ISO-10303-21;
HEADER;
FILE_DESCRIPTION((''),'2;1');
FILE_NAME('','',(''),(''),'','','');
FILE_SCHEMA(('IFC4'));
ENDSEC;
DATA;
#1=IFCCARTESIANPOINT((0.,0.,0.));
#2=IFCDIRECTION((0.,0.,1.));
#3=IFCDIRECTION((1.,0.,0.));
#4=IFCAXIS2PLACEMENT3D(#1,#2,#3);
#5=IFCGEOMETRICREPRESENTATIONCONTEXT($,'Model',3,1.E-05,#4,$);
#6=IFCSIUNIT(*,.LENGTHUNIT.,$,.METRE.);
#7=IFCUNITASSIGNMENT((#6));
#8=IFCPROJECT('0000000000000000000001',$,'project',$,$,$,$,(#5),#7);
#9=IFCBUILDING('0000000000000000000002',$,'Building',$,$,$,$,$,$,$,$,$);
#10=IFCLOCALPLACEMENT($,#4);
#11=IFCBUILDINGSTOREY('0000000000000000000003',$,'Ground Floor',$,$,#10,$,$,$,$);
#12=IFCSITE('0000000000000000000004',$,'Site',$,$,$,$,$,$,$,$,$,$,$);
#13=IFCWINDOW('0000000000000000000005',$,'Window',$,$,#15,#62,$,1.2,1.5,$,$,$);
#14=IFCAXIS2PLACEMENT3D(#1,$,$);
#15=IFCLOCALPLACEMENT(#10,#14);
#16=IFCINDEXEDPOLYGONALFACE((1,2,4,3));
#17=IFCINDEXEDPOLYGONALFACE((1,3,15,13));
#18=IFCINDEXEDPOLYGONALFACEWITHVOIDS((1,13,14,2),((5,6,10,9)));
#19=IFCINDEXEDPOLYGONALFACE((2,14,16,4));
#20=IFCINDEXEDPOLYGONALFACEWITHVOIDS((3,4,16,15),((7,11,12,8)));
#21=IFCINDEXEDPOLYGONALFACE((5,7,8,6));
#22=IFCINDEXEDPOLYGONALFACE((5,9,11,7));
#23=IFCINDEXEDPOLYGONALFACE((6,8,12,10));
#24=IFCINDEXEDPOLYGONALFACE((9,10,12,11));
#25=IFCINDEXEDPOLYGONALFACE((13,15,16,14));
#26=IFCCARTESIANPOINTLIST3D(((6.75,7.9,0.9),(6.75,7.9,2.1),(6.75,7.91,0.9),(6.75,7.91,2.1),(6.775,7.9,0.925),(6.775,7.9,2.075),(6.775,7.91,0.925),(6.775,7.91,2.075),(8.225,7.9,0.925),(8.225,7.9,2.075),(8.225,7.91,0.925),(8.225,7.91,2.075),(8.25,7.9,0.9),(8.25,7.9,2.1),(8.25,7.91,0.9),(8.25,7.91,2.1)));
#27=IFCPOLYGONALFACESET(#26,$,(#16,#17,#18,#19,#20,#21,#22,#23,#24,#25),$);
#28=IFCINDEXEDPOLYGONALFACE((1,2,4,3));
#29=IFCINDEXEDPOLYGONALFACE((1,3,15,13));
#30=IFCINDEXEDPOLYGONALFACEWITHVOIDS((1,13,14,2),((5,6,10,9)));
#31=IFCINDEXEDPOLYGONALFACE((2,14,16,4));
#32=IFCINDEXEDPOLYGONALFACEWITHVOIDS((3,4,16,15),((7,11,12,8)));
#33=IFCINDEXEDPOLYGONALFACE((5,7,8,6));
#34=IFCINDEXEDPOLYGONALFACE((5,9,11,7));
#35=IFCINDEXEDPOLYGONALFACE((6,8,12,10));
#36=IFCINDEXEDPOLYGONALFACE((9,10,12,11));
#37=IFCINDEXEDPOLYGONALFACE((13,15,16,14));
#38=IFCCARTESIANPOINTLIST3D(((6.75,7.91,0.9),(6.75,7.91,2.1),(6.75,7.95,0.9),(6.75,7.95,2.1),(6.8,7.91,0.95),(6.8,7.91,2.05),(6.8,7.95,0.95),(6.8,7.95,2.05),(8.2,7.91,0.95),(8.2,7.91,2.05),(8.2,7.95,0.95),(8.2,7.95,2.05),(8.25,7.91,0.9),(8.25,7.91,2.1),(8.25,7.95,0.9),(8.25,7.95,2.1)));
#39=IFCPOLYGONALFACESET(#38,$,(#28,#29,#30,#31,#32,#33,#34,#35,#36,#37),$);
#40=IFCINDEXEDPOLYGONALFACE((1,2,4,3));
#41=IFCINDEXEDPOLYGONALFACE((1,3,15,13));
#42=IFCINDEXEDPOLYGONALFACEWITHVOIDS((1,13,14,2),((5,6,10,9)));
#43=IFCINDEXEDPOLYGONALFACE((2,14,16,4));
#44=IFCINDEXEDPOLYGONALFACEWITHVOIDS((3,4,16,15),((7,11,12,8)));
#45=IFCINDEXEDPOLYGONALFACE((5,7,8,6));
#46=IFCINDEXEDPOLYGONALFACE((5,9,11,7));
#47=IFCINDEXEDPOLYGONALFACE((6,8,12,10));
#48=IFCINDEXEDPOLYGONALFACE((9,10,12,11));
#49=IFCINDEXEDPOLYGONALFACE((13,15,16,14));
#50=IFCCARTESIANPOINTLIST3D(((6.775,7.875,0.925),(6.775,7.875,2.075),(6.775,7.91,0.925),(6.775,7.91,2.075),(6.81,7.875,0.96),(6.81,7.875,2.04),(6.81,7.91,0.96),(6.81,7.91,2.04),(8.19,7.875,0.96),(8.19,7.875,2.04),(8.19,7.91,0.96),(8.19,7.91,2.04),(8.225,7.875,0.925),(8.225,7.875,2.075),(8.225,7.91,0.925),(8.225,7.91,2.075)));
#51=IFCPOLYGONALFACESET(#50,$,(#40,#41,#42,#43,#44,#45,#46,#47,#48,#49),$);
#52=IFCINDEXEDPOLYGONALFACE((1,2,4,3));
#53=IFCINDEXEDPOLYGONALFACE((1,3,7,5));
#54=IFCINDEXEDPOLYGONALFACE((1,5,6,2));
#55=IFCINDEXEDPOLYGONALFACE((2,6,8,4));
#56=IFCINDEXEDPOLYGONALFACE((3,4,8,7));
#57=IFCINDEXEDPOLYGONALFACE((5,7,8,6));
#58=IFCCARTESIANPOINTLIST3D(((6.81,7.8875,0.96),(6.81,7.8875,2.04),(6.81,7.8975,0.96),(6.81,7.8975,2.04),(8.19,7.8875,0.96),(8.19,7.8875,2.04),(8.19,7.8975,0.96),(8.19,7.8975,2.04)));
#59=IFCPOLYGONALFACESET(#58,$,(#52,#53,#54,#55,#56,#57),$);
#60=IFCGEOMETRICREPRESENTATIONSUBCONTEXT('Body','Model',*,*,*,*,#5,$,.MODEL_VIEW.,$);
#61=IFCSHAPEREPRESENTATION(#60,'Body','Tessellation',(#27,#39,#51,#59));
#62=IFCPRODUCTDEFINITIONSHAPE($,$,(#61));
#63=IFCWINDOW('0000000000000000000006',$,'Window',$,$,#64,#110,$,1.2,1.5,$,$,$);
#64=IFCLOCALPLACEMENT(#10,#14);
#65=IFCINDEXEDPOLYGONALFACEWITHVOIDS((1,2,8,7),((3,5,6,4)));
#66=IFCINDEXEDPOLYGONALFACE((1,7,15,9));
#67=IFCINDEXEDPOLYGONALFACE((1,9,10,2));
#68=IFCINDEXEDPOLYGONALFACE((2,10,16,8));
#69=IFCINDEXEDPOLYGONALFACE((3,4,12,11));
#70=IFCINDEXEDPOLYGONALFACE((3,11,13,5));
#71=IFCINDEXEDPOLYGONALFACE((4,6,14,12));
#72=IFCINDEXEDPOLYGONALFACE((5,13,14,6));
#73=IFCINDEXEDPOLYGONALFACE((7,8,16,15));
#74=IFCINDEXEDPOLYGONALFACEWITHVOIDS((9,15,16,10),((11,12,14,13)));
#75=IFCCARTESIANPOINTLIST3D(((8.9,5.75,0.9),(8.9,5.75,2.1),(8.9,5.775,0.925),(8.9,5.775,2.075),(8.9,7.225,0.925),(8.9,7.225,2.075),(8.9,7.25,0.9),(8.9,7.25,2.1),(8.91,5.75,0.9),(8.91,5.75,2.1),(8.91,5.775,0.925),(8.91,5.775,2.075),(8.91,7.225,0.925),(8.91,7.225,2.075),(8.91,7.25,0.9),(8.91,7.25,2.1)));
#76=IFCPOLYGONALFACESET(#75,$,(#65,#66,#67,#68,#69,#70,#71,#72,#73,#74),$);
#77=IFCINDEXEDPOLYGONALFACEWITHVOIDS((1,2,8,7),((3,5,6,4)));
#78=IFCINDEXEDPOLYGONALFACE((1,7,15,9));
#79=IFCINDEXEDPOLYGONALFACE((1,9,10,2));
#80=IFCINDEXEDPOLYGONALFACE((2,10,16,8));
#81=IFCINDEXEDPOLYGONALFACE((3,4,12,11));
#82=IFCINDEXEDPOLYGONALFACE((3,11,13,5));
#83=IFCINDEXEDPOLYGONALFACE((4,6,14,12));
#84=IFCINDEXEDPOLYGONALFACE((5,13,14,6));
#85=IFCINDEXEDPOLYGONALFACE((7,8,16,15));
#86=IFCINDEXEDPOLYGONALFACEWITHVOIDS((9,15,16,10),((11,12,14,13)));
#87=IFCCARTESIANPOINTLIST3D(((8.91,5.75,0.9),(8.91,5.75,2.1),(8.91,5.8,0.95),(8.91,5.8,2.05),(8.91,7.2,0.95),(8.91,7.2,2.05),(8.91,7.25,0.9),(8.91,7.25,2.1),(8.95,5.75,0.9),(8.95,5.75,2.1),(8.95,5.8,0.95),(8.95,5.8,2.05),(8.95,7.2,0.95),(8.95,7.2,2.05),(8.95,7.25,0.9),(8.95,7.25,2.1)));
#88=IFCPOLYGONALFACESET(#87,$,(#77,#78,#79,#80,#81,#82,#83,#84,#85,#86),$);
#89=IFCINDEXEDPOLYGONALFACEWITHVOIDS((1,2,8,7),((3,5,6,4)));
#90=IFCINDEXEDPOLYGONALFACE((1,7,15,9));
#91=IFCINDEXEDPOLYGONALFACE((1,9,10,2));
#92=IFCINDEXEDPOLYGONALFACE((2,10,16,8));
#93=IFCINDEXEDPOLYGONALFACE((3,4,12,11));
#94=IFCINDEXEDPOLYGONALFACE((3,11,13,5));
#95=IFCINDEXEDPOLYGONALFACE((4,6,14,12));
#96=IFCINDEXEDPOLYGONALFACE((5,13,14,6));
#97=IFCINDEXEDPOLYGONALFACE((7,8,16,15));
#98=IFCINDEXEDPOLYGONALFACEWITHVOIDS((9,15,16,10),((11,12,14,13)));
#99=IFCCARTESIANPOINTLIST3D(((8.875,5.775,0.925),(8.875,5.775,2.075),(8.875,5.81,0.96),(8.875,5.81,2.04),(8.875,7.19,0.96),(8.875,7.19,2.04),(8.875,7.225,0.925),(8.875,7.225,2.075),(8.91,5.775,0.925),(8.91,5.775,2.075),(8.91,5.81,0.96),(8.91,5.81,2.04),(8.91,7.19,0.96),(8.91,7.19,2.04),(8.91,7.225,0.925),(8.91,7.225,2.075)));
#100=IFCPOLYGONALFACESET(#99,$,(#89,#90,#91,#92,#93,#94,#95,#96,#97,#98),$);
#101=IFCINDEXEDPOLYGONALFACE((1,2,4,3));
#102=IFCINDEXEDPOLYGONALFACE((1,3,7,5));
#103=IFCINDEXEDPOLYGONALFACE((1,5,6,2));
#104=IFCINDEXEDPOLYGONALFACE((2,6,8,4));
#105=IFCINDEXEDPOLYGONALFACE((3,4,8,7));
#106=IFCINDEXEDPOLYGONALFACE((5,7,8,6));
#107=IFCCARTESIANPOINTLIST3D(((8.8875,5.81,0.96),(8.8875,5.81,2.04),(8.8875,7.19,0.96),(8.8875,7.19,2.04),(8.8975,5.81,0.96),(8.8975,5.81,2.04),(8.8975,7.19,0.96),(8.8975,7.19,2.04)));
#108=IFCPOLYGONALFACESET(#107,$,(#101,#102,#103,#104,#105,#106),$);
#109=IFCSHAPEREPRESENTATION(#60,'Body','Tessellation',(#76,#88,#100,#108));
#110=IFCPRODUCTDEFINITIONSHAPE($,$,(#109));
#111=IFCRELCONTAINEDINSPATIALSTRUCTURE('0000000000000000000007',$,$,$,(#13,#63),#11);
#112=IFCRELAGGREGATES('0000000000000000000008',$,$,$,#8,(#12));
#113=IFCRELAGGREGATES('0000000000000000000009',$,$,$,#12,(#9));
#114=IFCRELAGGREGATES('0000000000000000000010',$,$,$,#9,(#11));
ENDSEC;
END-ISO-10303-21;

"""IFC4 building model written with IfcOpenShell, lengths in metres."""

from ifc_helpers import new_model, si_unit, frame, origin_with_axes, place, context, subcontext, project, spatial, line, indexed_curve, outline, extrude, element, save


model = new_model("IFC4")

# Units and contexts
model_context = context("Model", 3, precision=1e-05, world=origin_with_axes())
body_context = subcontext(model_context, "Body", "Model", "MODEL_VIEW")
ifc_project = project(units=[si_unit("LENGTHUNIT", "METRE")], contexts=[model_context])

# Site, building, storey
site = spatial("IfcSite", under=ifc_project, Name="Site")
building = spatial("IfcBuilding", under=site, Name="Building")
storey_placement = place(None, origin_with_axes())
storey = spatial("IfcBuildingStorey", under=building, at=storey_placement, Name="Ground Floor")

# Windows
for number, where, z_axis, x_axis, name in (
    (1, (8.25, 8.0, 0.9), (0.0, 0.0, 1.0), (-1.0, 0.0, 0.0), "Window"),
    (2, (9.0, 5.75, 0.9), (0.0, 0.0, 1.0), (0.0, 1.0, 0.0), "Window"),
):
    element("IfcWindow", number, at=place(storey_placement, frame(where, z_axis=z_axis, x_axis=x_axis)), inside=storey, Name=name, OverallHeight=1.2, OverallWidth=1.5, context=body_context, shape_type="SweptSolid", body=[
        extrude(outline(indexed_curve([(0.0, 0.0), (1.5, 0.0), (1.5, 1.2), (0.0, 1.2)], segments=[line(1, 2, 3, 4, 1)]), holes=[indexed_curve([(0.025, 0.025), (1.475, 0.025), (1.475, 1.175), (0.025, 1.175)], segments=[line(1, 2, 3, 4, 1)])]), frame((0.0, 0.09, 0.0), z_axis=(0.0, -1.0, 0.0), x_axis=(1.0, 0.0, 0.0)), (0.0, 0.0, -1.0), 0.01),
        extrude(outline(indexed_curve([(0.0, 0.0), (1.5, 0.0), (1.5, 1.2), (0.0, 1.2)], segments=[line(1, 2, 3, 4, 1)]), holes=[indexed_curve([(0.05, 0.05), (1.45, 0.05), (1.45, 1.15), (0.05, 1.15)], segments=[line(1, 2, 3, 4, 1)])]), frame((0.0, 0.05, 0.0), z_axis=(0.0, -1.0, 0.0), x_axis=(1.0, 0.0, 0.0)), (0.0, 0.0, -1.0), 0.04),
        extrude(outline(indexed_curve([(0.0, 0.0), (1.45, 0.0), (1.45, 1.15), (0.0, 1.15)], segments=[line(1, 2, 3, 4, 1)]), holes=[indexed_curve([(0.035, 0.035), (1.415, 0.035), (1.415, 1.115), (0.035, 1.115)], segments=[line(1, 2, 3, 4, 1)])]), frame((0.025, 0.09, 0.025), z_axis=(0.0, -1.0, 0.0), x_axis=(1.0, 0.0, 0.0)), (0.0, 0.0, -1.0), 0.035),
        extrude(outline(indexed_curve([(0.035, 0.035), (1.415, 0.035), (1.415, 1.115), (0.035, 1.115)], segments=[line(1, 2, 3, 4, 1)])), frame((0.025, 0.1025, 0.025), z_axis=(0.0, -1.0, 0.0), x_axis=(1.0, 0.0, 0.0)), (0.0, 0.0, -1.0), 0.01),
    ])

save(model, "model.ifc")
